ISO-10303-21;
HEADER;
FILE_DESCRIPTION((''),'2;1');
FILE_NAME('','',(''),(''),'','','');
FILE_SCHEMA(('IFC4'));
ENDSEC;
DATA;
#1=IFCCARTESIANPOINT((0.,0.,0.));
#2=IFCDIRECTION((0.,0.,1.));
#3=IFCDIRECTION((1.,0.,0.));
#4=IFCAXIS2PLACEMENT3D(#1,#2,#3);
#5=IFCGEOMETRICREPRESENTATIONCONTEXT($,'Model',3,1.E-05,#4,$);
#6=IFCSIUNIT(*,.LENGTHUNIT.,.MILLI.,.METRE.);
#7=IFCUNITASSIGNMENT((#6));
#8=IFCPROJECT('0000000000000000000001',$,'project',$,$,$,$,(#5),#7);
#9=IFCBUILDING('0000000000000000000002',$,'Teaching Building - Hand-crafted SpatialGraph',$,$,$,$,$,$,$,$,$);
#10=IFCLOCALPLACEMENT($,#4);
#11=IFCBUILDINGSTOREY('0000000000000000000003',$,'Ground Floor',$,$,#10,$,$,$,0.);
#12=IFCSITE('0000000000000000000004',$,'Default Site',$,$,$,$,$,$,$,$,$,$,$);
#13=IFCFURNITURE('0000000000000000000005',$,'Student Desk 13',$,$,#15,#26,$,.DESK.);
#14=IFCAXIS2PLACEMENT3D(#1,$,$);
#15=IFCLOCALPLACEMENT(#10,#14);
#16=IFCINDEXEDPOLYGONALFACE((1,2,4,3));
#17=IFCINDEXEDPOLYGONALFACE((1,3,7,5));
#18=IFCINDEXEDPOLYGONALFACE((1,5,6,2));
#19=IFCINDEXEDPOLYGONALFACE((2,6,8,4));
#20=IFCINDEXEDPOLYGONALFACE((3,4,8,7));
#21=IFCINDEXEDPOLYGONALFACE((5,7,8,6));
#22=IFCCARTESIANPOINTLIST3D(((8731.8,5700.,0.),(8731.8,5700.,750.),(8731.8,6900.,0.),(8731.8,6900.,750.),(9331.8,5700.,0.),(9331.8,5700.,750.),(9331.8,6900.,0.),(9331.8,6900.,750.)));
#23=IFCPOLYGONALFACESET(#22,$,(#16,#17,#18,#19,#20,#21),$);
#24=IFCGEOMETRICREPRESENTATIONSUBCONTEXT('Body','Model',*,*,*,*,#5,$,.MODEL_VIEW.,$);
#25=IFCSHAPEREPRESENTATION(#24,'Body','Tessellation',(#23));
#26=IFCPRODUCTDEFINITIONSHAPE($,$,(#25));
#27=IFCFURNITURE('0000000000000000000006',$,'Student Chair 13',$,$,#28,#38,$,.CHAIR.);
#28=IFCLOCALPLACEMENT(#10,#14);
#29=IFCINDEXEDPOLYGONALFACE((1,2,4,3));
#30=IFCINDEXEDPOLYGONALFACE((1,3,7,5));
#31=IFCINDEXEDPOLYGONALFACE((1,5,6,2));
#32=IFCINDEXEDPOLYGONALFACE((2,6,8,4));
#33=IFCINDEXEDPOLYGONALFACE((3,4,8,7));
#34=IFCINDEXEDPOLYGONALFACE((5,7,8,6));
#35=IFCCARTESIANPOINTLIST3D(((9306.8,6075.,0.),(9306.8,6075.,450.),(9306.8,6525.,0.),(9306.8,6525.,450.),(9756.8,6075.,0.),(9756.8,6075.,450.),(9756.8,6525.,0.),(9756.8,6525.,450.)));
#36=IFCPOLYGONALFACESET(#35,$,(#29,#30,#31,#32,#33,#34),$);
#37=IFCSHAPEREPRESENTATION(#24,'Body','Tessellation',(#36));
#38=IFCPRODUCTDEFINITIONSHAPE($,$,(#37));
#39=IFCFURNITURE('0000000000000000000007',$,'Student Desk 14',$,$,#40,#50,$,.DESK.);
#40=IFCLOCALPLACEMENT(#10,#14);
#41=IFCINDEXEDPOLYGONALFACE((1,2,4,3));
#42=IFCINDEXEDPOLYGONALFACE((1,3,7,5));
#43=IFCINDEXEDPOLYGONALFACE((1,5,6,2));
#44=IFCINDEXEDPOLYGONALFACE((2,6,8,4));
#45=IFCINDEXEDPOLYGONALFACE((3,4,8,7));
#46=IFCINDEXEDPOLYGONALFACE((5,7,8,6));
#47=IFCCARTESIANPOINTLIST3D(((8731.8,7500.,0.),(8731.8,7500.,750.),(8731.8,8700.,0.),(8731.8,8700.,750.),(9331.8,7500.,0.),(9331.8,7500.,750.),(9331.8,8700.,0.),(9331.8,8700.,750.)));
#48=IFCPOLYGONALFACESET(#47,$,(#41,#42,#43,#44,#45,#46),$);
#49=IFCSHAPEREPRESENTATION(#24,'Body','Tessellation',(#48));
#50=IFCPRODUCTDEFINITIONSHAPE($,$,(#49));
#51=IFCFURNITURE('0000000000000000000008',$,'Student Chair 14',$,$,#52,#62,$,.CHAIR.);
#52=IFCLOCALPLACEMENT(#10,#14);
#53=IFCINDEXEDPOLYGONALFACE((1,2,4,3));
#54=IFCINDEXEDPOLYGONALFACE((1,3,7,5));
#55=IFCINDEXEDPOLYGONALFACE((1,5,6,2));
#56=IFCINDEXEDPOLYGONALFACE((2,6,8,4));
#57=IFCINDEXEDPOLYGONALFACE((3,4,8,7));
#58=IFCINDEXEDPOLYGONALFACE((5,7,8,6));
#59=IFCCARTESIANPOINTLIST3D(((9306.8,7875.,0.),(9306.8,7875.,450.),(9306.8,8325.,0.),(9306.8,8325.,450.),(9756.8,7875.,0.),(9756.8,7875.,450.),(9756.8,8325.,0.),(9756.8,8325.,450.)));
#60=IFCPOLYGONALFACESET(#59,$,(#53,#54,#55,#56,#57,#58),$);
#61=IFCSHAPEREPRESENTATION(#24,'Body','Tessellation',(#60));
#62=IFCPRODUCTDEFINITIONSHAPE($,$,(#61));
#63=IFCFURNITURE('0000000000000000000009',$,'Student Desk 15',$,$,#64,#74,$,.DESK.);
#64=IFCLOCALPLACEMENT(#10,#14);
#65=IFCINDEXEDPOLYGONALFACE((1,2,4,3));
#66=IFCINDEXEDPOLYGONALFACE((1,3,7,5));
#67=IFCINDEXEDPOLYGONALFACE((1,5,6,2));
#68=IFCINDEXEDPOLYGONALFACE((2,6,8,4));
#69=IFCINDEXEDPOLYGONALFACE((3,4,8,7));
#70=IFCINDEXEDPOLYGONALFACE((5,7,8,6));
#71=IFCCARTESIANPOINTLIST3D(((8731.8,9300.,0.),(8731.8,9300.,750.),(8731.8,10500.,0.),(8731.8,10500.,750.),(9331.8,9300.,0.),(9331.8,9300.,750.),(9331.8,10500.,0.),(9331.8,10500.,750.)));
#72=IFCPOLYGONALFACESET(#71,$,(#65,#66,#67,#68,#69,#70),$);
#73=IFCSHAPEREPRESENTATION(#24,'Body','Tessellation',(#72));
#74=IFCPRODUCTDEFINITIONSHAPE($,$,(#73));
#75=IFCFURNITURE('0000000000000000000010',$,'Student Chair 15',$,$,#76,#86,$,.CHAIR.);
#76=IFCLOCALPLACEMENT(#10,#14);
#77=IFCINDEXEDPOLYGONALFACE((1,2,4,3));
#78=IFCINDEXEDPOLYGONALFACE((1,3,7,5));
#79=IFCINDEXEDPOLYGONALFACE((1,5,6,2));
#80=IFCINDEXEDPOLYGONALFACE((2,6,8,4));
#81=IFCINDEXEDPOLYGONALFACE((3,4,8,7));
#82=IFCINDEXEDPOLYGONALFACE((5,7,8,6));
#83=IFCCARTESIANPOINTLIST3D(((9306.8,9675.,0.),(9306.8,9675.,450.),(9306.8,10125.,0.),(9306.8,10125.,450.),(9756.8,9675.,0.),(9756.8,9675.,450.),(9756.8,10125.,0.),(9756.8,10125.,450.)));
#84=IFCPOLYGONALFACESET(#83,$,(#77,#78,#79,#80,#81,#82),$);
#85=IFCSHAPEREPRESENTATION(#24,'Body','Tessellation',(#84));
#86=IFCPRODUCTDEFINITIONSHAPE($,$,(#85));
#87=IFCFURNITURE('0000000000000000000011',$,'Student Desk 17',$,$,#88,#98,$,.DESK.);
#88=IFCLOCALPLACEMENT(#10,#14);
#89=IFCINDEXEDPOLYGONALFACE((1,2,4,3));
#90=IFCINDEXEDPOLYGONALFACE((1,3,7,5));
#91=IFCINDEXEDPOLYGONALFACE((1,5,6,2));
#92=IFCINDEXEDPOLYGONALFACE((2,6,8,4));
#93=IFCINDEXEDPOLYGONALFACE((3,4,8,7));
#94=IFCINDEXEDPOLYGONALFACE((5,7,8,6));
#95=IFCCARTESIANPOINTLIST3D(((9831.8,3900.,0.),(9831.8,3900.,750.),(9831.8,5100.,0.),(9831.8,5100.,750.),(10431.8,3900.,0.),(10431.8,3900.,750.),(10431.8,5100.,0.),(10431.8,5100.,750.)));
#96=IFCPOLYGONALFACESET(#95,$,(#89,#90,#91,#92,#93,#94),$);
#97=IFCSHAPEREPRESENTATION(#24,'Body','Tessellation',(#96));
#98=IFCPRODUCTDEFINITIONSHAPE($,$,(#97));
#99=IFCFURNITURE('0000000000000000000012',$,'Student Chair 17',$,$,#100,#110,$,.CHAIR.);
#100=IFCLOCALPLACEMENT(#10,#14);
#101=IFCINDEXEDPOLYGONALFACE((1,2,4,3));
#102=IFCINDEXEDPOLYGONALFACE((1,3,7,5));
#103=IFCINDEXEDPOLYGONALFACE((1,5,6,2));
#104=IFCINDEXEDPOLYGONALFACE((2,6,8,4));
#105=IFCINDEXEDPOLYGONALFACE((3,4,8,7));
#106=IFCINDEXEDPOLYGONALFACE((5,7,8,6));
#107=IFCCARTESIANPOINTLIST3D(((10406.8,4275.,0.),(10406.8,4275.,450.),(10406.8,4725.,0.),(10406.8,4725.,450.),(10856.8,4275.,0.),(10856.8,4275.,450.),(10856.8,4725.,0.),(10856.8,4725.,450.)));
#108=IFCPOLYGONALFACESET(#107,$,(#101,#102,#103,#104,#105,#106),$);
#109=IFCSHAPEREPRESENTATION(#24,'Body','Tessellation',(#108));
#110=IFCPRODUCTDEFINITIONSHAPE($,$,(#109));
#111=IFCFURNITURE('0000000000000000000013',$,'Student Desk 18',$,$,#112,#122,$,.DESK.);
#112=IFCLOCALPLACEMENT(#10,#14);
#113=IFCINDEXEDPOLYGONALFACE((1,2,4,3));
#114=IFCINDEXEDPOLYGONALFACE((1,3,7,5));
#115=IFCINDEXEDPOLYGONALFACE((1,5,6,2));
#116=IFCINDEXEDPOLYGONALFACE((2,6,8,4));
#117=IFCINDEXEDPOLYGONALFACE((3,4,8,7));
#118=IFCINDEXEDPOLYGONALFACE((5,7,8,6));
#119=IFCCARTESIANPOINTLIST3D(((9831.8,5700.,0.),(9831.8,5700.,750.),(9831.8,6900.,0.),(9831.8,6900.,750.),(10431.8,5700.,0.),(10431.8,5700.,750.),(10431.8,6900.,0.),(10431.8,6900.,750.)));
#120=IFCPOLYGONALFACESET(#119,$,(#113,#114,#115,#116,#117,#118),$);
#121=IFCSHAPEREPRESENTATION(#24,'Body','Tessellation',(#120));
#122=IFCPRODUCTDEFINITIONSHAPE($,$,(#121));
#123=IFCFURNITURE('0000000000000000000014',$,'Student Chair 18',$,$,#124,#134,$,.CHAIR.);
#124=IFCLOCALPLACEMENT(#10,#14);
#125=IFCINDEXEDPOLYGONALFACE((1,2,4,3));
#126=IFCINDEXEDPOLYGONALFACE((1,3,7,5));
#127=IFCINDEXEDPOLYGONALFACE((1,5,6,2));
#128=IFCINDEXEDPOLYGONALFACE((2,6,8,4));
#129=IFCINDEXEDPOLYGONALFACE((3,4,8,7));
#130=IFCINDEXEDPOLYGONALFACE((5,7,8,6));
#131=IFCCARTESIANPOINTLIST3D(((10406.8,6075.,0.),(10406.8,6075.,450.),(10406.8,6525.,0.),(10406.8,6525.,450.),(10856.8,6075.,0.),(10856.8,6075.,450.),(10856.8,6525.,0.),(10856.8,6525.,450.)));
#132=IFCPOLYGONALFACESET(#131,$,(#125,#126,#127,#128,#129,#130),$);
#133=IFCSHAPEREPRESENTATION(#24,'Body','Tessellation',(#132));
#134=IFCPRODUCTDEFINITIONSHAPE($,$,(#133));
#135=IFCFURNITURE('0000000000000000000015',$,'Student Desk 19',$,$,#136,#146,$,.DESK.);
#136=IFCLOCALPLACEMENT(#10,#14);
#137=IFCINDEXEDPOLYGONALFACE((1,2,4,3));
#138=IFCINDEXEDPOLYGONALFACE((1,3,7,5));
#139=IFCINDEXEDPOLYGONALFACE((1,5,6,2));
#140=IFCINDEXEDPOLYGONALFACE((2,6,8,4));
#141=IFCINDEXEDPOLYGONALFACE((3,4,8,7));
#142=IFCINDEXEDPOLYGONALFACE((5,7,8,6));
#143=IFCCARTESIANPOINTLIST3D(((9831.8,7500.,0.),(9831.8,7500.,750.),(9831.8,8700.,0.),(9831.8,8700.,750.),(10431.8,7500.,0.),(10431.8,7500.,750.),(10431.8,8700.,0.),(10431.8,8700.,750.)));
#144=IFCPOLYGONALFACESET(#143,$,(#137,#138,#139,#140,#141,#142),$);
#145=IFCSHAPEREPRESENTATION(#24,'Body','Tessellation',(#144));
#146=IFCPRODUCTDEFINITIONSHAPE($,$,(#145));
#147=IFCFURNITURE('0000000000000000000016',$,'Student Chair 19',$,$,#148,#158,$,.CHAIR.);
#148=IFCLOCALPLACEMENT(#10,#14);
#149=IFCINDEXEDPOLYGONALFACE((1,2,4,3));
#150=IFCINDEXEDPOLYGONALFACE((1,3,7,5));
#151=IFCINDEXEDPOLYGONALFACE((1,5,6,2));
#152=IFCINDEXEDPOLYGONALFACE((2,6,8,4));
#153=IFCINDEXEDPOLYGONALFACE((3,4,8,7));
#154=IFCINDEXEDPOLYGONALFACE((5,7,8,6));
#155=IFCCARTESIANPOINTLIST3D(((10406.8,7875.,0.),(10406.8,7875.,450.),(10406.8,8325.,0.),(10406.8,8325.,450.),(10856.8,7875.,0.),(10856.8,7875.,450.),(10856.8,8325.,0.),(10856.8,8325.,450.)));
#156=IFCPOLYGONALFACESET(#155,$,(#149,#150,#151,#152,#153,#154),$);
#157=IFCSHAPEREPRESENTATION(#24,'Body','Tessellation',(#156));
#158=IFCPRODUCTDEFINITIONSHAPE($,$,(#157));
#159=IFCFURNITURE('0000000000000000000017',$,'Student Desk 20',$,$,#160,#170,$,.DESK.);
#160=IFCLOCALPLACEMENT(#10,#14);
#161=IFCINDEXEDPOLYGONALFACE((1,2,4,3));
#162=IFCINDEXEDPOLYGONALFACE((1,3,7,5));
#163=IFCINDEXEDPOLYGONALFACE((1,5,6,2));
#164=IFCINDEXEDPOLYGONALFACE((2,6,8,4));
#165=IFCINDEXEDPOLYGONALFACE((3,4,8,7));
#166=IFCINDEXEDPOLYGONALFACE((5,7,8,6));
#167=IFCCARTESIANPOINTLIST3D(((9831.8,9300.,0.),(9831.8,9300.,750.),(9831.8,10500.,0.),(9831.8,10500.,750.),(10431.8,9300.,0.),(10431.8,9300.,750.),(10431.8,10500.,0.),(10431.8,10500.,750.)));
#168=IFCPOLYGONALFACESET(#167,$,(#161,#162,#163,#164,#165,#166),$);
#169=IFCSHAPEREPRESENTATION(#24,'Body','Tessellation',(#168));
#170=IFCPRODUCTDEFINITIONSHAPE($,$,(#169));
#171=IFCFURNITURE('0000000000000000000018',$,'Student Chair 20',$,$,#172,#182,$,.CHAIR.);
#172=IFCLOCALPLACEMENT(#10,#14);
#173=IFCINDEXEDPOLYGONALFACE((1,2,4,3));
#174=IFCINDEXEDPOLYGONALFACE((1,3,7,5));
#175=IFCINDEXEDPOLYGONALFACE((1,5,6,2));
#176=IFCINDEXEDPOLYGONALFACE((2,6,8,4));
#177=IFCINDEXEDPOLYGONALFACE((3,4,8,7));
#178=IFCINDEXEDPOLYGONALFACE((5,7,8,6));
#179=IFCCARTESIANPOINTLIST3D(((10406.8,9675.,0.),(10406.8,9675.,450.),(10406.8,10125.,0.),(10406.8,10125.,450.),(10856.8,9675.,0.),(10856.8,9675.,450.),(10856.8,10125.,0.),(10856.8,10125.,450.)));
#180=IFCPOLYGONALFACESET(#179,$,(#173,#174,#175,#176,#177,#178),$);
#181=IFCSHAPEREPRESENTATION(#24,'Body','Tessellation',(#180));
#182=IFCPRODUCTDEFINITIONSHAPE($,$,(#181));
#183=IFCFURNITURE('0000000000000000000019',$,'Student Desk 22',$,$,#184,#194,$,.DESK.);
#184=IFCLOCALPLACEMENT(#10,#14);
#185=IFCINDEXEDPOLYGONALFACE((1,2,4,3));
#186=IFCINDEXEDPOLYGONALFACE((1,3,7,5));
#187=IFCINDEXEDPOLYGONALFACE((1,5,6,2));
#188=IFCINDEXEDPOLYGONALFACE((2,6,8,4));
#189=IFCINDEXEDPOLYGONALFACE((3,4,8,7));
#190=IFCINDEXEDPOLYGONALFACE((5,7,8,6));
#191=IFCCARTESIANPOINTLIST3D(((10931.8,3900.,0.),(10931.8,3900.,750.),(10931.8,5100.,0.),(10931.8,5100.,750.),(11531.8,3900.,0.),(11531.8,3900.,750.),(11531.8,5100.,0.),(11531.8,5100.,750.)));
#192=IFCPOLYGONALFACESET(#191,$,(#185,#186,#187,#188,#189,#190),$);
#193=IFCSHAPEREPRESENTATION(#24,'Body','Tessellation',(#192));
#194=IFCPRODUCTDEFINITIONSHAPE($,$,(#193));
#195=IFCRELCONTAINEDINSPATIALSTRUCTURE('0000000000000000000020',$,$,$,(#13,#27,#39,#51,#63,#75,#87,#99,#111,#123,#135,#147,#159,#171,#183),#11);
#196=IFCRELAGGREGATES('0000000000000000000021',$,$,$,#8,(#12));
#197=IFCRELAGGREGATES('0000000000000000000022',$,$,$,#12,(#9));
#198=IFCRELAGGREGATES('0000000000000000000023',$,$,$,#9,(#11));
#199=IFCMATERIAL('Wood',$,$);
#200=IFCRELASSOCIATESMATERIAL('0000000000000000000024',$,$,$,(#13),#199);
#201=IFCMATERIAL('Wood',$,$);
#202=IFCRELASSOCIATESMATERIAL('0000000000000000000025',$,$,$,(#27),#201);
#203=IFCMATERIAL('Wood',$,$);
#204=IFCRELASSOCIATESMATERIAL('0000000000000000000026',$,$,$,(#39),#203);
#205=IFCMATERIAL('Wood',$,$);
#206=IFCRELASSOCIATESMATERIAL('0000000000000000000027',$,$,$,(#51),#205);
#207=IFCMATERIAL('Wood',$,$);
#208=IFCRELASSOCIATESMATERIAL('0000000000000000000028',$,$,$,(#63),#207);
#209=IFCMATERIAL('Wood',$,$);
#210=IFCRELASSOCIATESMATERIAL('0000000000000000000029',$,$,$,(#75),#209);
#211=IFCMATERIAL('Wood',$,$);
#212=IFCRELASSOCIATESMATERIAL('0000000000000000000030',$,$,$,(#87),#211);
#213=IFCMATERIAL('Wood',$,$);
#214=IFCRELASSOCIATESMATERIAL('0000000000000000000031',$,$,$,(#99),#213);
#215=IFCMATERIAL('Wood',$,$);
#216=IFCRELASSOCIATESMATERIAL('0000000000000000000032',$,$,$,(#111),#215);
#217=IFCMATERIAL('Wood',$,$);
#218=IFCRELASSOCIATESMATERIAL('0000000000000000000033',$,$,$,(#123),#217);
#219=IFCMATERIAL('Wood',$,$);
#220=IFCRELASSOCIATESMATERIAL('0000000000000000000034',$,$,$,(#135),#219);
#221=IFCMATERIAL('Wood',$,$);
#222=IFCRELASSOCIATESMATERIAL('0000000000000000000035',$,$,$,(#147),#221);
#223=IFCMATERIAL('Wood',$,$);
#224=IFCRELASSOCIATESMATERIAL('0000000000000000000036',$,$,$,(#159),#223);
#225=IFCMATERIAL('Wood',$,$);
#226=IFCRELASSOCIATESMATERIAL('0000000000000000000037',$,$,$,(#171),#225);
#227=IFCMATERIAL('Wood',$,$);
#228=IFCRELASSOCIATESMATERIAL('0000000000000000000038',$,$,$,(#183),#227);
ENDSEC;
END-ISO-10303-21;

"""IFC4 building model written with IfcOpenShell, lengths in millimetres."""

from ifc_helpers import new_model, si_unit, frame, origin_with_axes, origin_2d, place, context, subcontext, project, spatial, rectangle, extrude, material, element, save


model = new_model("IFC4")

# Units and contexts
model_context = context("Model", 3, precision=1e-05, world=origin_with_axes())
body_context = subcontext(model_context, "Body", "Model", "MODEL_VIEW")
ifc_project = project(units=[si_unit("LENGTHUNIT", "METRE", prefix="MILLI")], contexts=[model_context])

# Site, building, storey
site = spatial("IfcSite", under=ifc_project, Name="Default Site")
building = spatial("IfcBuilding", under=site, Name="Teaching Building - Hand-crafted SpatialGraph")
storey_placement = place(None, origin_with_axes())
storey = spatial("IfcBuildingStorey", under=building, at=storey_placement, Name="Ground Floor", Elevation=0.0)

# Furniture
ifc_material_1 = material(Name="Wood")
furniture_1_placement = place(storey_placement, frame((9031.8, 6300.0, 0.0), z_axis=(0.0, 0.0, 1.0), x_axis=(0.0, 1.0, 0.0)))
element("IfcFurniture", 1, at=furniture_1_placement, inside=storey, material=ifc_material_1, Name="Student Desk 13", PredefinedType="DESK", context=body_context, shape_type="SweptSolid", body=[
    extrude(rectangle(XDim=1200.0, YDim=600.0, at=origin_2d()), origin_with_axes(), (0.0, 0.0, 1.0), 750.0),
])
ifc_material_2 = material(Name="Wood")
furniture_2_placement = place(storey_placement, frame((9531.8, 6300.0, 0.0), z_axis=(0.0, 0.0, 1.0), x_axis=(1.0, 0.0, 0.0)))
element("IfcFurniture", 2, at=furniture_2_placement, inside=storey, material=ifc_material_2, Name="Student Chair 13", PredefinedType="CHAIR", context=body_context, shape_type="SweptSolid", body=[
    extrude(rectangle(XDim=450.0, YDim=450.0, at=origin_2d()), origin_with_axes(), (0.0, 0.0, 1.0), 450.0),
])
ifc_material_3 = material(Name="Wood")
furniture_3_placement = place(storey_placement, frame((9031.8, 8100.0, 0.0), z_axis=(0.0, 0.0, 1.0), x_axis=(0.0, 1.0, 0.0)))
element("IfcFurniture", 3, at=furniture_3_placement, inside=storey, material=ifc_material_3, Name="Student Desk 14", PredefinedType="DESK", context=body_context, shape_type="SweptSolid", body=[
    extrude(rectangle(XDim=1200.0, YDim=600.0, at=origin_2d()), origin_with_axes(), (0.0, 0.0, 1.0), 750.0),
])
ifc_material_4 = material(Name="Wood")
furniture_4_placement = place(storey_placement, frame((9531.8, 8100.0, 0.0), z_axis=(0.0, 0.0, 1.0), x_axis=(1.0, 0.0, 0.0)))
element("IfcFurniture", 4, at=furniture_4_placement, inside=storey, material=ifc_material_4, Name="Student Chair 14", PredefinedType="CHAIR", context=body_context, shape_type="SweptSolid", body=[
    extrude(rectangle(XDim=450.0, YDim=450.0, at=origin_2d()), origin_with_axes(), (0.0, 0.0, 1.0), 450.0),
])
ifc_material_5 = material(Name="Wood")
furniture_5_placement = place(storey_placement, frame((9031.8, 9900.0, 0.0), z_axis=(0.0, 0.0, 1.0), x_axis=(0.0, 1.0, 0.0)))
element("IfcFurniture", 5, at=furniture_5_placement, inside=storey, material=ifc_material_5, Name="Student Desk 15", PredefinedType="DESK", context=body_context, shape_type="SweptSolid", body=[
    extrude(rectangle(XDim=1200.0, YDim=600.0, at=origin_2d()), origin_with_axes(), (0.0, 0.0, 1.0), 750.0),
])
ifc_material_6 = material(Name="Wood")
furniture_6_placement = place(storey_placement, frame((9531.8, 9900.0, 0.0), z_axis=(0.0, 0.0, 1.0), x_axis=(1.0, 0.0, 0.0)))
element("IfcFurniture", 6, at=furniture_6_placement, inside=storey, material=ifc_material_6, Name="Student Chair 15", PredefinedType="CHAIR", context=body_context, shape_type="SweptSolid", body=[
    extrude(rectangle(XDim=450.0, YDim=450.0, at=origin_2d()), origin_with_axes(), (0.0, 0.0, 1.0), 450.0),
])
ifc_material_7 = material(Name="Wood")
furniture_7_placement = place(storey_placement, frame((10131.8, 4500.0, 0.0), z_axis=(0.0, 0.0, 1.0), x_axis=(0.0, 1.0, 0.0)))
element("IfcFurniture", 7, at=furniture_7_placement, inside=storey, material=ifc_material_7, Name="Student Desk 17", PredefinedType="DESK", context=body_context, shape_type="SweptSolid", body=[
    extrude(rectangle(XDim=1200.0, YDim=600.0, at=origin_2d()), origin_with_axes(), (0.0, 0.0, 1.0), 750.0),
])
ifc_material_8 = material(Name="Wood")
furniture_8_placement = place(storey_placement, frame((10631.8, 4500.0, 0.0), z_axis=(0.0, 0.0, 1.0), x_axis=(1.0, 0.0, 0.0)))
element("IfcFurniture", 8, at=furniture_8_placement, inside=storey, material=ifc_material_8, Name="Student Chair 17", PredefinedType="CHAIR", context=body_context, shape_type="SweptSolid", body=[
    extrude(rectangle(XDim=450.0, YDim=450.0, at=origin_2d()), origin_with_axes(), (0.0, 0.0, 1.0), 450.0),
])
ifc_material_9 = material(Name="Wood")
furniture_9_placement = place(storey_placement, frame((10131.8, 6300.0, 0.0), z_axis=(0.0, 0.0, 1.0), x_axis=(0.0, 1.0, 0.0)))
element("IfcFurniture", 9, at=furniture_9_placement, inside=storey, material=ifc_material_9, Name="Student Desk 18", PredefinedType="DESK", context=body_context, shape_type="SweptSolid", body=[
    extrude(rectangle(XDim=1200.0, YDim=600.0, at=origin_2d()), origin_with_axes(), (0.0, 0.0, 1.0), 750.0),
])
ifc_material_10 = material(Name="Wood")
furniture_10_placement = place(storey_placement, frame((10631.8, 6300.0, 0.0), z_axis=(0.0, 0.0, 1.0), x_axis=(1.0, 0.0, 0.0)))
element("IfcFurniture", 10, at=furniture_10_placement, inside=storey, material=ifc_material_10, Name="Student Chair 18", PredefinedType="CHAIR", context=body_context, shape_type="SweptSolid", body=[
    extrude(rectangle(XDim=450.0, YDim=450.0, at=origin_2d()), origin_with_axes(), (0.0, 0.0, 1.0), 450.0),
])
ifc_material_11 = material(Name="Wood")
furniture_11_placement = place(storey_placement, frame((10131.8, 8100.0, 0.0), z_axis=(0.0, 0.0, 1.0), x_axis=(0.0, 1.0, 0.0)))
element("IfcFurniture", 11, at=furniture_11_placement, inside=storey, material=ifc_material_11, Name="Student Desk 19", PredefinedType="DESK", context=body_context, shape_type="SweptSolid", body=[
    extrude(rectangle(XDim=1200.0, YDim=600.0, at=origin_2d()), origin_with_axes(), (0.0, 0.0, 1.0), 750.0),
])
ifc_material_12 = material(Name="Wood")
furniture_12_placement = place(storey_placement, frame((10631.8, 8100.0, 0.0), z_axis=(0.0, 0.0, 1.0), x_axis=(1.0, 0.0, 0.0)))
element("IfcFurniture", 12, at=furniture_12_placement, inside=storey, material=ifc_material_12, Name="Student Chair 19", PredefinedType="CHAIR", context=body_context, shape_type="SweptSolid", body=[
    extrude(rectangle(XDim=450.0, YDim=450.0, at=origin_2d()), origin_with_axes(), (0.0, 0.0, 1.0), 450.0),
])
ifc_material_13 = material(Name="Wood")
furniture_13_placement = place(storey_placement, frame((10131.8, 9900.0, 0.0), z_axis=(0.0, 0.0, 1.0), x_axis=(0.0, 1.0, 0.0)))
element("IfcFurniture", 13, at=furniture_13_placement, inside=storey, material=ifc_material_13, Name="Student Desk 20", PredefinedType="DESK", context=body_context, shape_type="SweptSolid", body=[
    extrude(rectangle(XDim=1200.0, YDim=600.0, at=origin_2d()), origin_with_axes(), (0.0, 0.0, 1.0), 750.0),
])
ifc_material_14 = material(Name="Wood")
furniture_14_placement = place(storey_placement, frame((10631.8, 9900.0, 0.0), z_axis=(0.0, 0.0, 1.0), x_axis=(1.0, 0.0, 0.0)))
element("IfcFurniture", 14, at=furniture_14_placement, inside=storey, material=ifc_material_14, Name="Student Chair 20", PredefinedType="CHAIR", context=body_context, shape_type="SweptSolid", body=[
    extrude(rectangle(XDim=450.0, YDim=450.0, at=origin_2d()), origin_with_axes(), (0.0, 0.0, 1.0), 450.0),
])
ifc_material_15 = material(Name="Wood")
furniture_15_placement = place(storey_placement, frame((11231.8, 4500.0, 0.0), z_axis=(0.0, 0.0, 1.0), x_axis=(0.0, 1.0, 0.0)))
element("IfcFurniture", 15, at=furniture_15_placement, inside=storey, material=ifc_material_15, Name="Student Desk 22", PredefinedType="DESK", context=body_context, shape_type="SweptSolid", body=[
    extrude(rectangle(XDim=1200.0, YDim=600.0, at=origin_2d()), origin_with_axes(), (0.0, 0.0, 1.0), 750.0),
])

save(model, "model.ifc")
